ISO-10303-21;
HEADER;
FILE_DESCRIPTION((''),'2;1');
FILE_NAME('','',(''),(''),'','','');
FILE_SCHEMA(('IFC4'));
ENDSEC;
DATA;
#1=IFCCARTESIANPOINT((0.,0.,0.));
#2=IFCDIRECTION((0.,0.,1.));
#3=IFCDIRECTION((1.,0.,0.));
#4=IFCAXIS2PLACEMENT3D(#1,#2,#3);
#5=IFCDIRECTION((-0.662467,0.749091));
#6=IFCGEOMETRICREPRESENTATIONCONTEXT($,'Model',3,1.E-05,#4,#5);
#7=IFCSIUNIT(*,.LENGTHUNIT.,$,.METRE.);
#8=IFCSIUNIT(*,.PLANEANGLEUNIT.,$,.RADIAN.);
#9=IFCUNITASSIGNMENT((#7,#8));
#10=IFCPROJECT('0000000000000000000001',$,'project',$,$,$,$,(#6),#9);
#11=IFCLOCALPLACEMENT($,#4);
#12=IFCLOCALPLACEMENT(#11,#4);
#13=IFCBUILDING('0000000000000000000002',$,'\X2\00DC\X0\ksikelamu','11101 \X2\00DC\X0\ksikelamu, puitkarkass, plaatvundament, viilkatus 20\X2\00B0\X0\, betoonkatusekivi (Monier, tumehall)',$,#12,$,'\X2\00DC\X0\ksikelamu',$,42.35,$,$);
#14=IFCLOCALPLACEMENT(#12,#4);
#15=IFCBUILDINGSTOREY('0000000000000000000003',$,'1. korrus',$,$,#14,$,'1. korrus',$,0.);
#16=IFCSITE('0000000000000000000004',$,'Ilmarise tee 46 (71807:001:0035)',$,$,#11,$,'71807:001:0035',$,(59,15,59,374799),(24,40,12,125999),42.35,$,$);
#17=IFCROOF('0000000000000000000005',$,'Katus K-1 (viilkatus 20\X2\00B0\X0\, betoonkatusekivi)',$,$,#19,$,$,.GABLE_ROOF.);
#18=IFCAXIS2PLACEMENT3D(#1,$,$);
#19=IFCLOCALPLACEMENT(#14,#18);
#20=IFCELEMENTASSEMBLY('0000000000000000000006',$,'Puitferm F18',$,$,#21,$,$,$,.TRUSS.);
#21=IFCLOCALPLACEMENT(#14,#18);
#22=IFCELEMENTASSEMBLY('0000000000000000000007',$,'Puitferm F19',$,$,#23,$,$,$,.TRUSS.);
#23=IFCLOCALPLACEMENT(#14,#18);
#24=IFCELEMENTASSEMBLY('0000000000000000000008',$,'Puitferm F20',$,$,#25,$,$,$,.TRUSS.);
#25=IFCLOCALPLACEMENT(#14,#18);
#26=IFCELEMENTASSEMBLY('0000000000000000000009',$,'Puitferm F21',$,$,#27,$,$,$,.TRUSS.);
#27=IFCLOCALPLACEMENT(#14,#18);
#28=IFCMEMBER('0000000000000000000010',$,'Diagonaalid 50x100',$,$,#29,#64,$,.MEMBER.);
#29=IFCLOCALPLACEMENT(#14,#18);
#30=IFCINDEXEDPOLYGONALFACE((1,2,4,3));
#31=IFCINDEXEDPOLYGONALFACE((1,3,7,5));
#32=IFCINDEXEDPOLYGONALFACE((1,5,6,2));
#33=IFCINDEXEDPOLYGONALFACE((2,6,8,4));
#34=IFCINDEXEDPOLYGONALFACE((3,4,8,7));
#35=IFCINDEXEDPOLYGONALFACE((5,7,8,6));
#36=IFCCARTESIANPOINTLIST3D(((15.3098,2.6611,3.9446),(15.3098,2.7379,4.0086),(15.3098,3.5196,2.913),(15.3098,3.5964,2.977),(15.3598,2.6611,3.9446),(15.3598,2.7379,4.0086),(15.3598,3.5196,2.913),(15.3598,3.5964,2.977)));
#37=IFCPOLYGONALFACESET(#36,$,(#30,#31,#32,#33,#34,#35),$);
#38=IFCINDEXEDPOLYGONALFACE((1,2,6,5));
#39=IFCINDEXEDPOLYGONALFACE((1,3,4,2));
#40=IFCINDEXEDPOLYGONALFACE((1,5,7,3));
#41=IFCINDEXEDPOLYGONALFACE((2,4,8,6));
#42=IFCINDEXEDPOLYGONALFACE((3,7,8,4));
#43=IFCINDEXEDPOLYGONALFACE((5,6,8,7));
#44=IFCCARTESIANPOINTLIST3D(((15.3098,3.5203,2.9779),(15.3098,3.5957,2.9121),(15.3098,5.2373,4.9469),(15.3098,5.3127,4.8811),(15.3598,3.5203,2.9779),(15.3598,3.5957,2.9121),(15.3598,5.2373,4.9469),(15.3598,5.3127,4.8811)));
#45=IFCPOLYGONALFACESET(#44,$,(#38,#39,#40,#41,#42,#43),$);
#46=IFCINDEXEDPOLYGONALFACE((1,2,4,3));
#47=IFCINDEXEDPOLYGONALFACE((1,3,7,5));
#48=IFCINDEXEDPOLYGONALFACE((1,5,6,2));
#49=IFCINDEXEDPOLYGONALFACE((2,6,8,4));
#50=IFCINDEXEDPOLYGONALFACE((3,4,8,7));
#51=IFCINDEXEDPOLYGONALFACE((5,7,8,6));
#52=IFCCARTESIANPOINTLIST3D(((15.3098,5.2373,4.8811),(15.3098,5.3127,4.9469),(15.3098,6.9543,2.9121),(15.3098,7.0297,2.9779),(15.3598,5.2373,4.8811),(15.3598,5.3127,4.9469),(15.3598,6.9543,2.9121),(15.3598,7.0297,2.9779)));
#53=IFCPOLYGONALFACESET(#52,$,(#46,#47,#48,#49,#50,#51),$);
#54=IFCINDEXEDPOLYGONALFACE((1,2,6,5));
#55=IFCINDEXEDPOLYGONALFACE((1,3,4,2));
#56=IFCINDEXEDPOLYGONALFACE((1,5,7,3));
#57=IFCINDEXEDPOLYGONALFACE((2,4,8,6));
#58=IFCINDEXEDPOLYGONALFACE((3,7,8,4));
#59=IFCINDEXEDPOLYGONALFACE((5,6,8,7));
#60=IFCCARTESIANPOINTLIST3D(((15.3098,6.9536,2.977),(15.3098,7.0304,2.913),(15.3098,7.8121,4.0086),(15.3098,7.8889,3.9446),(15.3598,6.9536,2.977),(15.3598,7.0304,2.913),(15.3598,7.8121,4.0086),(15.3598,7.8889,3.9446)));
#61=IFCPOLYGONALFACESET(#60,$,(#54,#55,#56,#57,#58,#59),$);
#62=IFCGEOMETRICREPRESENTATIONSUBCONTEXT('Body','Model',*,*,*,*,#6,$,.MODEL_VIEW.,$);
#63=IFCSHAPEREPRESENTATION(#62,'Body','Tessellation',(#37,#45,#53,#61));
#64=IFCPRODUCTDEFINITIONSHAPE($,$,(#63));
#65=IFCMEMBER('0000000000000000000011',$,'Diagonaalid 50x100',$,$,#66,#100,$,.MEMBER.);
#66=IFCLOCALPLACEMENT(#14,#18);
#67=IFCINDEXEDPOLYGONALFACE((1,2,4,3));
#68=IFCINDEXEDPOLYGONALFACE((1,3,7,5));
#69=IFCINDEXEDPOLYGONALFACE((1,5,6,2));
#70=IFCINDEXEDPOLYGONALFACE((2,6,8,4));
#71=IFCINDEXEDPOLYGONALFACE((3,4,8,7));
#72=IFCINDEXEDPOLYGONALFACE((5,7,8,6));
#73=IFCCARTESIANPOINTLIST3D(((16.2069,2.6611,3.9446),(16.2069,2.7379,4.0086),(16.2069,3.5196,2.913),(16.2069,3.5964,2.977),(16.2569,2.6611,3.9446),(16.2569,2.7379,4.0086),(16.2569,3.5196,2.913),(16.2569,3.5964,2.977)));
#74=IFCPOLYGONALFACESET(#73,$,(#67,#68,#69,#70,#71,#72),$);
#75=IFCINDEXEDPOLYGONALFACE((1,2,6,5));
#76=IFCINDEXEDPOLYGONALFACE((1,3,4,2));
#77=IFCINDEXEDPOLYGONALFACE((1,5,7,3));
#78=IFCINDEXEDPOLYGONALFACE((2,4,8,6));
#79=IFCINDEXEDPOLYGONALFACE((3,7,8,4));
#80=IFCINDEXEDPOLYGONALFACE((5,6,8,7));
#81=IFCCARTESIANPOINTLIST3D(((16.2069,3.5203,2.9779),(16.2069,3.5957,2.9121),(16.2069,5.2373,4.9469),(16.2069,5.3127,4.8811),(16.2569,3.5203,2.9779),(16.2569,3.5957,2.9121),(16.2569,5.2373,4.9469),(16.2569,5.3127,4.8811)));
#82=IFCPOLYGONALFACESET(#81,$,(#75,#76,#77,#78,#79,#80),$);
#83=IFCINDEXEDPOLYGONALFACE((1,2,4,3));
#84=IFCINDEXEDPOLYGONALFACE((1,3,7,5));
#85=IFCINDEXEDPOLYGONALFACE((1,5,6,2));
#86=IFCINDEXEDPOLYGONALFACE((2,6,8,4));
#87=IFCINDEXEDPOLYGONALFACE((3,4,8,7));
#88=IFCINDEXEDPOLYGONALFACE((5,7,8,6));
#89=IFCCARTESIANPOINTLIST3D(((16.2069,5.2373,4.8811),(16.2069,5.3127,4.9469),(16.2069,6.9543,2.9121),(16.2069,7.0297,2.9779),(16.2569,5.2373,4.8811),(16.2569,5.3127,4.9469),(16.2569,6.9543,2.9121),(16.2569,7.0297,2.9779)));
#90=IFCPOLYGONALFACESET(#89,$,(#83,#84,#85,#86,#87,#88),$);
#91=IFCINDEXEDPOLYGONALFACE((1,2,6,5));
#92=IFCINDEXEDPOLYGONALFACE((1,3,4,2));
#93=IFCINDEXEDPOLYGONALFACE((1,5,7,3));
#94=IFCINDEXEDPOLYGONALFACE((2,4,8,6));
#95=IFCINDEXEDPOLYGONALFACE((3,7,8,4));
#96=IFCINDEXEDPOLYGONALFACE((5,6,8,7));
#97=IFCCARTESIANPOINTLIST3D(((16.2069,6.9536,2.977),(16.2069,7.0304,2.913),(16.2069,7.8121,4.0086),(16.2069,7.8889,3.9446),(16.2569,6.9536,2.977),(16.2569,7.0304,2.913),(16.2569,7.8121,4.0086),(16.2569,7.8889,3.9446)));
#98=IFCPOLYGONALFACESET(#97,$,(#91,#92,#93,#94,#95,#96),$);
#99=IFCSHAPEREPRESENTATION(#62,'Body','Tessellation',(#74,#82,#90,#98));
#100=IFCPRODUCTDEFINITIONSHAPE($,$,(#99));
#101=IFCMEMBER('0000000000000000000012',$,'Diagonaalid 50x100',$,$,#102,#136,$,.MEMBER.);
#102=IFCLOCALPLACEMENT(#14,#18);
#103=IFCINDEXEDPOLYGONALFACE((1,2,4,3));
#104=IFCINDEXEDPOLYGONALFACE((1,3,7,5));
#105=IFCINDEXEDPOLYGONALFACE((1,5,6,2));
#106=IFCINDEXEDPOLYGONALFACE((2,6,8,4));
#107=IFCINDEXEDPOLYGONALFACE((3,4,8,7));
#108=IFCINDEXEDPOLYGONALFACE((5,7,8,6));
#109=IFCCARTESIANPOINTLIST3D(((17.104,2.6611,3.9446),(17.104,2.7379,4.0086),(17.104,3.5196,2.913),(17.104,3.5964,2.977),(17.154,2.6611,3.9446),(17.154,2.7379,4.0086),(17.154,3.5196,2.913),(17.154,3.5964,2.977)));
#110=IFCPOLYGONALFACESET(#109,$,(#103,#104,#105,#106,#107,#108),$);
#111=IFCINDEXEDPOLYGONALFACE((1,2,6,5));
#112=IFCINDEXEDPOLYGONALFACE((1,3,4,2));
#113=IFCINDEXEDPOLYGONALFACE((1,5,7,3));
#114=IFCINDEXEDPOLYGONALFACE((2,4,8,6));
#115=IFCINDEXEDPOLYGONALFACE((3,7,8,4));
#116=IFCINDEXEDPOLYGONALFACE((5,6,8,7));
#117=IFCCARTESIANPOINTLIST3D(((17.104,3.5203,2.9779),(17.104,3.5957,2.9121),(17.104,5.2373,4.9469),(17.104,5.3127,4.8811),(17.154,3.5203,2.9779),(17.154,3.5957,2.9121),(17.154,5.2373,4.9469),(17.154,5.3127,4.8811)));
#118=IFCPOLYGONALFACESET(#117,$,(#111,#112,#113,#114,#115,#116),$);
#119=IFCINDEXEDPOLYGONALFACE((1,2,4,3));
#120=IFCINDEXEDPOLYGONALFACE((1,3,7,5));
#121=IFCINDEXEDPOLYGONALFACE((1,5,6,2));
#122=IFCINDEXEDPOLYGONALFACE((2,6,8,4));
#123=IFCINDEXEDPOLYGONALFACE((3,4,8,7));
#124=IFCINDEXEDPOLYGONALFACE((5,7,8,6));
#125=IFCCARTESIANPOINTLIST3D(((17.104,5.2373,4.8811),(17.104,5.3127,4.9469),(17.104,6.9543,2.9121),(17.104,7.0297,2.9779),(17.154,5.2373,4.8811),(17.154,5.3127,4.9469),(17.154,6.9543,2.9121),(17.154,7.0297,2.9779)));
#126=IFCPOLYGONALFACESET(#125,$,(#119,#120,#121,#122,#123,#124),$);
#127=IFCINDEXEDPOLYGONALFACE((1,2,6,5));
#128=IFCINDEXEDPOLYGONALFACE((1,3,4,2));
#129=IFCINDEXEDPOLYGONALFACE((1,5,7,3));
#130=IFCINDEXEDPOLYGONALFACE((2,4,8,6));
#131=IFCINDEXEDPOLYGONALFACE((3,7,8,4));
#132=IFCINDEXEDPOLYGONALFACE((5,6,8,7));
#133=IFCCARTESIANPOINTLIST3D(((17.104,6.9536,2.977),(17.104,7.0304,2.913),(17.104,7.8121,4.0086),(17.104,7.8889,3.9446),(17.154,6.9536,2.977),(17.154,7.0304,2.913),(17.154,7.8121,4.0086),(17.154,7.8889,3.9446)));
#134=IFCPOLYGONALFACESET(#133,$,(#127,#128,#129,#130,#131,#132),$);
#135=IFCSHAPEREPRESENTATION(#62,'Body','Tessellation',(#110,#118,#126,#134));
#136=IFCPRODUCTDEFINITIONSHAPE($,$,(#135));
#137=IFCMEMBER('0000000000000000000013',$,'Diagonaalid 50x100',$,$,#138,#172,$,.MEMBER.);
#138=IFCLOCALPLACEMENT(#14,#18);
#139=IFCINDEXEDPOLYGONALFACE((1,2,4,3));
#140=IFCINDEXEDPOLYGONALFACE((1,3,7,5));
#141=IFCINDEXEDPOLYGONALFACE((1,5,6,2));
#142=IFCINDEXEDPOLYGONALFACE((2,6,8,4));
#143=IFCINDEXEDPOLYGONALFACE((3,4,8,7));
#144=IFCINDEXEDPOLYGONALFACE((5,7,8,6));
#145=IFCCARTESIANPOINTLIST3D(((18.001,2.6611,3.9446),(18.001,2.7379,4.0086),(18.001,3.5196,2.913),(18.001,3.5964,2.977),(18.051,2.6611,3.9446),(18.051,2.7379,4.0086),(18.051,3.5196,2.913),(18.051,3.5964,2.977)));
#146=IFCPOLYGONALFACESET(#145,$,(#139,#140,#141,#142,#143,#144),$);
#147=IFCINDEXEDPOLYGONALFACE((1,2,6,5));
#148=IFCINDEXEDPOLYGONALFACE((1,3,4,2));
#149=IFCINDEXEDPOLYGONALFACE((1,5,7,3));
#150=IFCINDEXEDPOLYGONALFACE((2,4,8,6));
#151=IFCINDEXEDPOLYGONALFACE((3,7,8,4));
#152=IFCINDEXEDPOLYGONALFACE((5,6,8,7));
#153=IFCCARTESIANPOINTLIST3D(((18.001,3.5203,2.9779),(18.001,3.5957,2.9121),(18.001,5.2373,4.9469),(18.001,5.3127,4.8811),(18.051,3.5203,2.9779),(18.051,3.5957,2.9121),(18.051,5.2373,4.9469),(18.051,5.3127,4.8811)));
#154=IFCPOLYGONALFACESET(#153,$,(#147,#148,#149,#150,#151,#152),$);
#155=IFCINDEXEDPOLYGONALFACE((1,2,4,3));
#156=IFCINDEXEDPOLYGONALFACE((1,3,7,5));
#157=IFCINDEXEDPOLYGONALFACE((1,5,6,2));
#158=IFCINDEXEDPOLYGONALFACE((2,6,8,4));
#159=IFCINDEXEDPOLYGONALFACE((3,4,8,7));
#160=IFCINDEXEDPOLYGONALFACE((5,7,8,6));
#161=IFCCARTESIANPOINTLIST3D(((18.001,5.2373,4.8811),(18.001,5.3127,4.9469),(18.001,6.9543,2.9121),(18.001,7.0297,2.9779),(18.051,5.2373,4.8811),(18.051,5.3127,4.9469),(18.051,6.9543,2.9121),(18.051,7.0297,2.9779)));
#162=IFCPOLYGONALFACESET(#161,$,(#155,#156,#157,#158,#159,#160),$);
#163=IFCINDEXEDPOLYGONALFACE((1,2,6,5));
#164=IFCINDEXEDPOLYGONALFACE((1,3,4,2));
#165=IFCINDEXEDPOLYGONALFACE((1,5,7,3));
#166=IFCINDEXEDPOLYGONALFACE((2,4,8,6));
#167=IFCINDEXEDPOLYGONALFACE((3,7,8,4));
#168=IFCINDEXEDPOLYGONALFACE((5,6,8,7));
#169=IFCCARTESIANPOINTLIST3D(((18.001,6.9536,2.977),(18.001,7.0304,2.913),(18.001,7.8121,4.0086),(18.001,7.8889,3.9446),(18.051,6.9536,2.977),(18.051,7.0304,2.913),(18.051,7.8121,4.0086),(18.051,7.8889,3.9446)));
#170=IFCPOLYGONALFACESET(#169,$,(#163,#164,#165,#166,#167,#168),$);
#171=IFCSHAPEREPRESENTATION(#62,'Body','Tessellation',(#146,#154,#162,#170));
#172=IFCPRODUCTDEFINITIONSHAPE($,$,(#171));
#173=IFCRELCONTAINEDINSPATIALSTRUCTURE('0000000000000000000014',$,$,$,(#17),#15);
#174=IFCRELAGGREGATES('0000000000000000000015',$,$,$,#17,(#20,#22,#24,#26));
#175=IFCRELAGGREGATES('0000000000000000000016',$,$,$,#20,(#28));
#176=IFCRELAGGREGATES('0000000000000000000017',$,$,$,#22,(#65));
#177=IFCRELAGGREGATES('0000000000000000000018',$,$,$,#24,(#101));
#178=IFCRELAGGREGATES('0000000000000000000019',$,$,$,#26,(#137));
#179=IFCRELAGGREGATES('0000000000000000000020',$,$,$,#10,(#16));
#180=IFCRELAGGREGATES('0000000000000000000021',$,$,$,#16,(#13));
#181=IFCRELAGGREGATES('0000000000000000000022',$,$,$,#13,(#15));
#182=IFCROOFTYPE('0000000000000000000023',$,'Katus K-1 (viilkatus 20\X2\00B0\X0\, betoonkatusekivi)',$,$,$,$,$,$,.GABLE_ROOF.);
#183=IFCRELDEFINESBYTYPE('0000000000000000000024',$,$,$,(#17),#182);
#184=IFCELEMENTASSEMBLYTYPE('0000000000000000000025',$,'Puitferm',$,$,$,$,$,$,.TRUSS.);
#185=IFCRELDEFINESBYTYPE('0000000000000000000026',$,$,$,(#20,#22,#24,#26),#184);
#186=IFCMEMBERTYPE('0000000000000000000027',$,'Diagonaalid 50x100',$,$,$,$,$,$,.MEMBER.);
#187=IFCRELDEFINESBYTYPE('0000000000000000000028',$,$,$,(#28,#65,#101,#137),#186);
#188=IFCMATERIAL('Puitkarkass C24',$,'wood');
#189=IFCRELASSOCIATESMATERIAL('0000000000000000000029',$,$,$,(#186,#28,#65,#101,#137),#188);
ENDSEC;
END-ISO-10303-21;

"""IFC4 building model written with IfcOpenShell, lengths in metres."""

from ifc_helpers import new_model, si_unit, direction, frame, origin_with_axes, place, context, subcontext, project, spatial, indexed_curve, outline, extrude, material, type_object, element, aggregate, save


model = new_model("IFC4")

# Units and contexts
model_context = context("Model", 3, precision=1e-05, world=origin_with_axes(), true_north=direction((-0.662467, 0.749091)))
body_context = subcontext(model_context, "Body", "Model", "MODEL_VIEW")
ifc_project = project(units=[si_unit("LENGTHUNIT", "METRE"), si_unit("PLANEANGLEUNIT", "RADIAN")], contexts=[model_context])

# Site, building, storey
site_placement = place(None, origin_with_axes())
site = spatial("IfcSite", under=ifc_project, at=site_placement, Name="Ilmarise tee 46 (71807:001:0035)", LongName="71807:001:0035", RefLatitude=(59, 15, 59, 374799), RefLongitude=(24, 40, 12, 125999), RefElevation=42.35)
building_placement = place(site_placement, origin_with_axes())
building = spatial("IfcBuilding", under=site, at=building_placement, Name="Üksikelamu", Description="11101 Üksikelamu, puitkarkass, plaatvundament, viilkatus 20°, betoonkatusekivi (Monier, tumehall)", LongName="Üksikelamu", ElevationOfRefHeight=42.35)
storey_placement = place(building_placement, origin_with_axes())
storey = spatial("IfcBuildingStorey", under=building, at=storey_placement, Name="1. korrus", LongName="1. korrus", Elevation=0.0)

# Roof, element assemblies, members
roof_type = type_object("IfcRoofType", Name="Katus K-1 (viilkatus 20°, betoonkatusekivi)", PredefinedType="GABLE_ROOF")
roof_placement = place(storey_placement, origin_with_axes())
roof = element("IfcRoof", 1, at=roof_placement, inside=storey, type_object=roof_type, Name="Katus K-1 (viilkatus 20°, betoonkatusekivi)", PredefinedType="GABLE_ROOF")
element_assembly_type = type_object("IfcElementAssemblyType", Name="Puitferm", PredefinedType="TRUSS")
ifc_material = material(Name="Puitkarkass C24", Category="wood")
assembly_1_placement = place(roof_placement, origin_with_axes())
assembly_1 = element("IfcElementAssembly", 2, at=assembly_1_placement, type_object=element_assembly_type, Name="Puitferm F18", PredefinedType="TRUSS")
assembly_2_placement = place(roof_placement, origin_with_axes())
assembly_2 = element("IfcElementAssembly", 3, at=assembly_2_placement, type_object=element_assembly_type, Name="Puitferm F19", PredefinedType="TRUSS")
assembly_3_placement = place(roof_placement, origin_with_axes())
assembly_3 = element("IfcElementAssembly", 4, at=assembly_3_placement, type_object=element_assembly_type, Name="Puitferm F20", PredefinedType="TRUSS")
assembly_4_placement = place(roof_placement, origin_with_axes())
assembly_4 = element("IfcElementAssembly", 5, at=assembly_4_placement, type_object=element_assembly_type, Name="Puitferm F21", PredefinedType="TRUSS")
aggregate(roof, [assembly_1, assembly_2, assembly_3, assembly_4])
member_type_1 = type_object("IfcMemberType", Name="Diagonaalid 50x100", PredefinedType="MEMBER", material=ifc_material)
member_1_placement = place(assembly_1_placement, origin_with_axes())
member_1 = element("IfcMember", 6, at=member_1_placement, type_object=member_type_1, material=ifc_material, Name="Diagonaalid 50x100", PredefinedType="MEMBER", context=body_context, shape_type="SweptSolid", body=[
    extrude(outline(indexed_curve([(3.5196, 2.913), (2.6611, 3.9446), (2.7379, 4.0086), (3.5964, 2.977), (3.5196, 2.913)], self_intersect=False)), frame((15.3098, 0.0, 0.0), z_axis=(1.0, 0.0, 0.0), x_axis=(0.0, 1.0, 0.0)), (0.0, 0.0, 1.0), 0.05),
    extrude(outline(indexed_curve([(3.5203, 2.9779), (5.2373, 4.9469), (5.3127, 4.8811), (3.5957, 2.9121), (3.5203, 2.9779)], self_intersect=False)), frame((15.3098, 0.0, 0.0), z_axis=(1.0, 0.0, 0.0), x_axis=(0.0, 1.0, 0.0)), (0.0, 0.0, 1.0), 0.05),
    extrude(outline(indexed_curve([(6.9543, 2.9121), (5.2373, 4.8811), (5.3127, 4.9469), (7.0297, 2.9779), (6.9543, 2.9121)], self_intersect=False)), frame((15.3098, 0.0, 0.0), z_axis=(1.0, 0.0, 0.0), x_axis=(0.0, 1.0, 0.0)), (0.0, 0.0, 1.0), 0.05),
    extrude(outline(indexed_curve([(6.9536, 2.977), (7.8121, 4.0086), (7.8889, 3.9446), (7.0304, 2.913), (6.9536, 2.977)], self_intersect=False)), frame((15.3098, 0.0, 0.0), z_axis=(1.0, 0.0, 0.0), x_axis=(0.0, 1.0, 0.0)), (0.0, 0.0, 1.0), 0.05),
])
aggregate(assembly_1, [member_1])
member_2_placement = place(assembly_2_placement, origin_with_axes())
member_2 = element("IfcMember", 7, at=member_2_placement, type_object=member_type_1, material=ifc_material, Name="Diagonaalid 50x100", PredefinedType="MEMBER", context=body_context, shape_type="SweptSolid", body=[
    extrude(outline(indexed_curve([(3.5196, 2.913), (2.6611, 3.9446), (2.7379, 4.0086), (3.5964, 2.977), (3.5196, 2.913)], self_intersect=False)), frame((16.2069, 0.0, 0.0), z_axis=(1.0, 0.0, 0.0), x_axis=(0.0, 1.0, 0.0)), (0.0, 0.0, 1.0), 0.05),
    extrude(outline(indexed_curve([(3.5203, 2.9779), (5.2373, 4.9469), (5.3127, 4.8811), (3.5957, 2.9121), (3.5203, 2.9779)], self_intersect=False)), frame((16.2069, 0.0, 0.0), z_axis=(1.0, 0.0, 0.0), x_axis=(0.0, 1.0, 0.0)), (0.0, 0.0, 1.0), 0.05),
    extrude(outline(indexed_curve([(6.9543, 2.9121), (5.2373, 4.8811), (5.3127, 4.9469), (7.0297, 2.9779), (6.9543, 2.9121)], self_intersect=False)), frame((16.2069, 0.0, 0.0), z_axis=(1.0, 0.0, 0.0), x_axis=(0.0, 1.0, 0.0)), (0.0, 0.0, 1.0), 0.05),
    extrude(outline(indexed_curve([(6.9536, 2.977), (7.8121, 4.0086), (7.8889, 3.9446), (7.0304, 2.913), (6.9536, 2.977)], self_intersect=False)), frame((16.2069, 0.0, 0.0), z_axis=(1.0, 0.0, 0.0), x_axis=(0.0, 1.0, 0.0)), (0.0, 0.0, 1.0), 0.05),
])
aggregate(assembly_2, [member_2])
member_3_placement = place(assembly_3_placement, origin_with_axes())
member_3 = element("IfcMember", 8, at=member_3_placement, type_object=member_type_1, material=ifc_material, Name="Diagonaalid 50x100", PredefinedType="MEMBER", context=body_context, shape_type="SweptSolid", body=[
    extrude(outline(indexed_curve([(3.5196, 2.913), (2.6611, 3.9446), (2.7379, 4.0086), (3.5964, 2.977), (3.5196, 2.913)], self_intersect=False)), frame((17.104, 0.0, 0.0), z_axis=(1.0, 0.0, 0.0), x_axis=(0.0, 1.0, 0.0)), (0.0, 0.0, 1.0), 0.05),
    extrude(outline(indexed_curve([(3.5203, 2.9779), (5.2373, 4.9469), (5.3127, 4.8811), (3.5957, 2.9121), (3.5203, 2.9779)], self_intersect=False)), frame((17.104, 0.0, 0.0), z_axis=(1.0, 0.0, 0.0), x_axis=(0.0, 1.0, 0.0)), (0.0, 0.0, 1.0), 0.05),
    extrude(outline(indexed_curve([(6.9543, 2.9121), (5.2373, 4.8811), (5.3127, 4.9469), (7.0297, 2.9779), (6.9543, 2.9121)], self_intersect=False)), frame((17.104, 0.0, 0.0), z_axis=(1.0, 0.0, 0.0), x_axis=(0.0, 1.0, 0.0)), (0.0, 0.0, 1.0), 0.05),
    extrude(outline(indexed_curve([(6.9536, 2.977), (7.8121, 4.0086), (7.8889, 3.9446), (7.0304, 2.913), (6.9536, 2.977)], self_intersect=False)), frame((17.104, 0.0, 0.0), z_axis=(1.0, 0.0, 0.0), x_axis=(0.0, 1.0, 0.0)), (0.0, 0.0, 1.0), 0.05),
])
aggregate(assembly_3, [member_3])
member_4_placement = place(assembly_4_placement, origin_with_axes())
member_4 = element("IfcMember", 9, at=member_4_placement, type_object=member_type_1, material=ifc_material, Name="Diagonaalid 50x100", PredefinedType="MEMBER", context=body_context, shape_type="SweptSolid", body=[
    extrude(outline(indexed_curve([(3.5196, 2.913), (2.6611, 3.9446), (2.7379, 4.0086), (3.5964, 2.977), (3.5196, 2.913)], self_intersect=False)), frame((18.001, 0.0, 0.0), z_axis=(1.0, 0.0, 0.0), x_axis=(0.0, 1.0, 0.0)), (0.0, 0.0, 1.0), 0.05),
    extrude(outline(indexed_curve([(3.5203, 2.9779), (5.2373, 4.9469), (5.3127, 4.8811), (3.5957, 2.9121), (3.5203, 2.9779)], self_intersect=False)), frame((18.001, 0.0, 0.0), z_axis=(1.0, 0.0, 0.0), x_axis=(0.0, 1.0, 0.0)), (0.0, 0.0, 1.0), 0.05),
    extrude(outline(indexed_curve([(6.9543, 2.9121), (5.2373, 4.8811), (5.3127, 4.9469), (7.0297, 2.9779), (6.9543, 2.9121)], self_intersect=False)), frame((18.001, 0.0, 0.0), z_axis=(1.0, 0.0, 0.0), x_axis=(0.0, 1.0, 0.0)), (0.0, 0.0, 1.0), 0.05),
    extrude(outline(indexed_curve([(6.9536, 2.977), (7.8121, 4.0086), (7.8889, 3.9446), (7.0304, 2.913), (6.9536, 2.977)], self_intersect=False)), frame((18.001, 0.0, 0.0), z_axis=(1.0, 0.0, 0.0), x_axis=(0.0, 1.0, 0.0)), (0.0, 0.0, 1.0), 0.05),
])
aggregate(assembly_4, [member_4])

save(model, "model.ifc")
